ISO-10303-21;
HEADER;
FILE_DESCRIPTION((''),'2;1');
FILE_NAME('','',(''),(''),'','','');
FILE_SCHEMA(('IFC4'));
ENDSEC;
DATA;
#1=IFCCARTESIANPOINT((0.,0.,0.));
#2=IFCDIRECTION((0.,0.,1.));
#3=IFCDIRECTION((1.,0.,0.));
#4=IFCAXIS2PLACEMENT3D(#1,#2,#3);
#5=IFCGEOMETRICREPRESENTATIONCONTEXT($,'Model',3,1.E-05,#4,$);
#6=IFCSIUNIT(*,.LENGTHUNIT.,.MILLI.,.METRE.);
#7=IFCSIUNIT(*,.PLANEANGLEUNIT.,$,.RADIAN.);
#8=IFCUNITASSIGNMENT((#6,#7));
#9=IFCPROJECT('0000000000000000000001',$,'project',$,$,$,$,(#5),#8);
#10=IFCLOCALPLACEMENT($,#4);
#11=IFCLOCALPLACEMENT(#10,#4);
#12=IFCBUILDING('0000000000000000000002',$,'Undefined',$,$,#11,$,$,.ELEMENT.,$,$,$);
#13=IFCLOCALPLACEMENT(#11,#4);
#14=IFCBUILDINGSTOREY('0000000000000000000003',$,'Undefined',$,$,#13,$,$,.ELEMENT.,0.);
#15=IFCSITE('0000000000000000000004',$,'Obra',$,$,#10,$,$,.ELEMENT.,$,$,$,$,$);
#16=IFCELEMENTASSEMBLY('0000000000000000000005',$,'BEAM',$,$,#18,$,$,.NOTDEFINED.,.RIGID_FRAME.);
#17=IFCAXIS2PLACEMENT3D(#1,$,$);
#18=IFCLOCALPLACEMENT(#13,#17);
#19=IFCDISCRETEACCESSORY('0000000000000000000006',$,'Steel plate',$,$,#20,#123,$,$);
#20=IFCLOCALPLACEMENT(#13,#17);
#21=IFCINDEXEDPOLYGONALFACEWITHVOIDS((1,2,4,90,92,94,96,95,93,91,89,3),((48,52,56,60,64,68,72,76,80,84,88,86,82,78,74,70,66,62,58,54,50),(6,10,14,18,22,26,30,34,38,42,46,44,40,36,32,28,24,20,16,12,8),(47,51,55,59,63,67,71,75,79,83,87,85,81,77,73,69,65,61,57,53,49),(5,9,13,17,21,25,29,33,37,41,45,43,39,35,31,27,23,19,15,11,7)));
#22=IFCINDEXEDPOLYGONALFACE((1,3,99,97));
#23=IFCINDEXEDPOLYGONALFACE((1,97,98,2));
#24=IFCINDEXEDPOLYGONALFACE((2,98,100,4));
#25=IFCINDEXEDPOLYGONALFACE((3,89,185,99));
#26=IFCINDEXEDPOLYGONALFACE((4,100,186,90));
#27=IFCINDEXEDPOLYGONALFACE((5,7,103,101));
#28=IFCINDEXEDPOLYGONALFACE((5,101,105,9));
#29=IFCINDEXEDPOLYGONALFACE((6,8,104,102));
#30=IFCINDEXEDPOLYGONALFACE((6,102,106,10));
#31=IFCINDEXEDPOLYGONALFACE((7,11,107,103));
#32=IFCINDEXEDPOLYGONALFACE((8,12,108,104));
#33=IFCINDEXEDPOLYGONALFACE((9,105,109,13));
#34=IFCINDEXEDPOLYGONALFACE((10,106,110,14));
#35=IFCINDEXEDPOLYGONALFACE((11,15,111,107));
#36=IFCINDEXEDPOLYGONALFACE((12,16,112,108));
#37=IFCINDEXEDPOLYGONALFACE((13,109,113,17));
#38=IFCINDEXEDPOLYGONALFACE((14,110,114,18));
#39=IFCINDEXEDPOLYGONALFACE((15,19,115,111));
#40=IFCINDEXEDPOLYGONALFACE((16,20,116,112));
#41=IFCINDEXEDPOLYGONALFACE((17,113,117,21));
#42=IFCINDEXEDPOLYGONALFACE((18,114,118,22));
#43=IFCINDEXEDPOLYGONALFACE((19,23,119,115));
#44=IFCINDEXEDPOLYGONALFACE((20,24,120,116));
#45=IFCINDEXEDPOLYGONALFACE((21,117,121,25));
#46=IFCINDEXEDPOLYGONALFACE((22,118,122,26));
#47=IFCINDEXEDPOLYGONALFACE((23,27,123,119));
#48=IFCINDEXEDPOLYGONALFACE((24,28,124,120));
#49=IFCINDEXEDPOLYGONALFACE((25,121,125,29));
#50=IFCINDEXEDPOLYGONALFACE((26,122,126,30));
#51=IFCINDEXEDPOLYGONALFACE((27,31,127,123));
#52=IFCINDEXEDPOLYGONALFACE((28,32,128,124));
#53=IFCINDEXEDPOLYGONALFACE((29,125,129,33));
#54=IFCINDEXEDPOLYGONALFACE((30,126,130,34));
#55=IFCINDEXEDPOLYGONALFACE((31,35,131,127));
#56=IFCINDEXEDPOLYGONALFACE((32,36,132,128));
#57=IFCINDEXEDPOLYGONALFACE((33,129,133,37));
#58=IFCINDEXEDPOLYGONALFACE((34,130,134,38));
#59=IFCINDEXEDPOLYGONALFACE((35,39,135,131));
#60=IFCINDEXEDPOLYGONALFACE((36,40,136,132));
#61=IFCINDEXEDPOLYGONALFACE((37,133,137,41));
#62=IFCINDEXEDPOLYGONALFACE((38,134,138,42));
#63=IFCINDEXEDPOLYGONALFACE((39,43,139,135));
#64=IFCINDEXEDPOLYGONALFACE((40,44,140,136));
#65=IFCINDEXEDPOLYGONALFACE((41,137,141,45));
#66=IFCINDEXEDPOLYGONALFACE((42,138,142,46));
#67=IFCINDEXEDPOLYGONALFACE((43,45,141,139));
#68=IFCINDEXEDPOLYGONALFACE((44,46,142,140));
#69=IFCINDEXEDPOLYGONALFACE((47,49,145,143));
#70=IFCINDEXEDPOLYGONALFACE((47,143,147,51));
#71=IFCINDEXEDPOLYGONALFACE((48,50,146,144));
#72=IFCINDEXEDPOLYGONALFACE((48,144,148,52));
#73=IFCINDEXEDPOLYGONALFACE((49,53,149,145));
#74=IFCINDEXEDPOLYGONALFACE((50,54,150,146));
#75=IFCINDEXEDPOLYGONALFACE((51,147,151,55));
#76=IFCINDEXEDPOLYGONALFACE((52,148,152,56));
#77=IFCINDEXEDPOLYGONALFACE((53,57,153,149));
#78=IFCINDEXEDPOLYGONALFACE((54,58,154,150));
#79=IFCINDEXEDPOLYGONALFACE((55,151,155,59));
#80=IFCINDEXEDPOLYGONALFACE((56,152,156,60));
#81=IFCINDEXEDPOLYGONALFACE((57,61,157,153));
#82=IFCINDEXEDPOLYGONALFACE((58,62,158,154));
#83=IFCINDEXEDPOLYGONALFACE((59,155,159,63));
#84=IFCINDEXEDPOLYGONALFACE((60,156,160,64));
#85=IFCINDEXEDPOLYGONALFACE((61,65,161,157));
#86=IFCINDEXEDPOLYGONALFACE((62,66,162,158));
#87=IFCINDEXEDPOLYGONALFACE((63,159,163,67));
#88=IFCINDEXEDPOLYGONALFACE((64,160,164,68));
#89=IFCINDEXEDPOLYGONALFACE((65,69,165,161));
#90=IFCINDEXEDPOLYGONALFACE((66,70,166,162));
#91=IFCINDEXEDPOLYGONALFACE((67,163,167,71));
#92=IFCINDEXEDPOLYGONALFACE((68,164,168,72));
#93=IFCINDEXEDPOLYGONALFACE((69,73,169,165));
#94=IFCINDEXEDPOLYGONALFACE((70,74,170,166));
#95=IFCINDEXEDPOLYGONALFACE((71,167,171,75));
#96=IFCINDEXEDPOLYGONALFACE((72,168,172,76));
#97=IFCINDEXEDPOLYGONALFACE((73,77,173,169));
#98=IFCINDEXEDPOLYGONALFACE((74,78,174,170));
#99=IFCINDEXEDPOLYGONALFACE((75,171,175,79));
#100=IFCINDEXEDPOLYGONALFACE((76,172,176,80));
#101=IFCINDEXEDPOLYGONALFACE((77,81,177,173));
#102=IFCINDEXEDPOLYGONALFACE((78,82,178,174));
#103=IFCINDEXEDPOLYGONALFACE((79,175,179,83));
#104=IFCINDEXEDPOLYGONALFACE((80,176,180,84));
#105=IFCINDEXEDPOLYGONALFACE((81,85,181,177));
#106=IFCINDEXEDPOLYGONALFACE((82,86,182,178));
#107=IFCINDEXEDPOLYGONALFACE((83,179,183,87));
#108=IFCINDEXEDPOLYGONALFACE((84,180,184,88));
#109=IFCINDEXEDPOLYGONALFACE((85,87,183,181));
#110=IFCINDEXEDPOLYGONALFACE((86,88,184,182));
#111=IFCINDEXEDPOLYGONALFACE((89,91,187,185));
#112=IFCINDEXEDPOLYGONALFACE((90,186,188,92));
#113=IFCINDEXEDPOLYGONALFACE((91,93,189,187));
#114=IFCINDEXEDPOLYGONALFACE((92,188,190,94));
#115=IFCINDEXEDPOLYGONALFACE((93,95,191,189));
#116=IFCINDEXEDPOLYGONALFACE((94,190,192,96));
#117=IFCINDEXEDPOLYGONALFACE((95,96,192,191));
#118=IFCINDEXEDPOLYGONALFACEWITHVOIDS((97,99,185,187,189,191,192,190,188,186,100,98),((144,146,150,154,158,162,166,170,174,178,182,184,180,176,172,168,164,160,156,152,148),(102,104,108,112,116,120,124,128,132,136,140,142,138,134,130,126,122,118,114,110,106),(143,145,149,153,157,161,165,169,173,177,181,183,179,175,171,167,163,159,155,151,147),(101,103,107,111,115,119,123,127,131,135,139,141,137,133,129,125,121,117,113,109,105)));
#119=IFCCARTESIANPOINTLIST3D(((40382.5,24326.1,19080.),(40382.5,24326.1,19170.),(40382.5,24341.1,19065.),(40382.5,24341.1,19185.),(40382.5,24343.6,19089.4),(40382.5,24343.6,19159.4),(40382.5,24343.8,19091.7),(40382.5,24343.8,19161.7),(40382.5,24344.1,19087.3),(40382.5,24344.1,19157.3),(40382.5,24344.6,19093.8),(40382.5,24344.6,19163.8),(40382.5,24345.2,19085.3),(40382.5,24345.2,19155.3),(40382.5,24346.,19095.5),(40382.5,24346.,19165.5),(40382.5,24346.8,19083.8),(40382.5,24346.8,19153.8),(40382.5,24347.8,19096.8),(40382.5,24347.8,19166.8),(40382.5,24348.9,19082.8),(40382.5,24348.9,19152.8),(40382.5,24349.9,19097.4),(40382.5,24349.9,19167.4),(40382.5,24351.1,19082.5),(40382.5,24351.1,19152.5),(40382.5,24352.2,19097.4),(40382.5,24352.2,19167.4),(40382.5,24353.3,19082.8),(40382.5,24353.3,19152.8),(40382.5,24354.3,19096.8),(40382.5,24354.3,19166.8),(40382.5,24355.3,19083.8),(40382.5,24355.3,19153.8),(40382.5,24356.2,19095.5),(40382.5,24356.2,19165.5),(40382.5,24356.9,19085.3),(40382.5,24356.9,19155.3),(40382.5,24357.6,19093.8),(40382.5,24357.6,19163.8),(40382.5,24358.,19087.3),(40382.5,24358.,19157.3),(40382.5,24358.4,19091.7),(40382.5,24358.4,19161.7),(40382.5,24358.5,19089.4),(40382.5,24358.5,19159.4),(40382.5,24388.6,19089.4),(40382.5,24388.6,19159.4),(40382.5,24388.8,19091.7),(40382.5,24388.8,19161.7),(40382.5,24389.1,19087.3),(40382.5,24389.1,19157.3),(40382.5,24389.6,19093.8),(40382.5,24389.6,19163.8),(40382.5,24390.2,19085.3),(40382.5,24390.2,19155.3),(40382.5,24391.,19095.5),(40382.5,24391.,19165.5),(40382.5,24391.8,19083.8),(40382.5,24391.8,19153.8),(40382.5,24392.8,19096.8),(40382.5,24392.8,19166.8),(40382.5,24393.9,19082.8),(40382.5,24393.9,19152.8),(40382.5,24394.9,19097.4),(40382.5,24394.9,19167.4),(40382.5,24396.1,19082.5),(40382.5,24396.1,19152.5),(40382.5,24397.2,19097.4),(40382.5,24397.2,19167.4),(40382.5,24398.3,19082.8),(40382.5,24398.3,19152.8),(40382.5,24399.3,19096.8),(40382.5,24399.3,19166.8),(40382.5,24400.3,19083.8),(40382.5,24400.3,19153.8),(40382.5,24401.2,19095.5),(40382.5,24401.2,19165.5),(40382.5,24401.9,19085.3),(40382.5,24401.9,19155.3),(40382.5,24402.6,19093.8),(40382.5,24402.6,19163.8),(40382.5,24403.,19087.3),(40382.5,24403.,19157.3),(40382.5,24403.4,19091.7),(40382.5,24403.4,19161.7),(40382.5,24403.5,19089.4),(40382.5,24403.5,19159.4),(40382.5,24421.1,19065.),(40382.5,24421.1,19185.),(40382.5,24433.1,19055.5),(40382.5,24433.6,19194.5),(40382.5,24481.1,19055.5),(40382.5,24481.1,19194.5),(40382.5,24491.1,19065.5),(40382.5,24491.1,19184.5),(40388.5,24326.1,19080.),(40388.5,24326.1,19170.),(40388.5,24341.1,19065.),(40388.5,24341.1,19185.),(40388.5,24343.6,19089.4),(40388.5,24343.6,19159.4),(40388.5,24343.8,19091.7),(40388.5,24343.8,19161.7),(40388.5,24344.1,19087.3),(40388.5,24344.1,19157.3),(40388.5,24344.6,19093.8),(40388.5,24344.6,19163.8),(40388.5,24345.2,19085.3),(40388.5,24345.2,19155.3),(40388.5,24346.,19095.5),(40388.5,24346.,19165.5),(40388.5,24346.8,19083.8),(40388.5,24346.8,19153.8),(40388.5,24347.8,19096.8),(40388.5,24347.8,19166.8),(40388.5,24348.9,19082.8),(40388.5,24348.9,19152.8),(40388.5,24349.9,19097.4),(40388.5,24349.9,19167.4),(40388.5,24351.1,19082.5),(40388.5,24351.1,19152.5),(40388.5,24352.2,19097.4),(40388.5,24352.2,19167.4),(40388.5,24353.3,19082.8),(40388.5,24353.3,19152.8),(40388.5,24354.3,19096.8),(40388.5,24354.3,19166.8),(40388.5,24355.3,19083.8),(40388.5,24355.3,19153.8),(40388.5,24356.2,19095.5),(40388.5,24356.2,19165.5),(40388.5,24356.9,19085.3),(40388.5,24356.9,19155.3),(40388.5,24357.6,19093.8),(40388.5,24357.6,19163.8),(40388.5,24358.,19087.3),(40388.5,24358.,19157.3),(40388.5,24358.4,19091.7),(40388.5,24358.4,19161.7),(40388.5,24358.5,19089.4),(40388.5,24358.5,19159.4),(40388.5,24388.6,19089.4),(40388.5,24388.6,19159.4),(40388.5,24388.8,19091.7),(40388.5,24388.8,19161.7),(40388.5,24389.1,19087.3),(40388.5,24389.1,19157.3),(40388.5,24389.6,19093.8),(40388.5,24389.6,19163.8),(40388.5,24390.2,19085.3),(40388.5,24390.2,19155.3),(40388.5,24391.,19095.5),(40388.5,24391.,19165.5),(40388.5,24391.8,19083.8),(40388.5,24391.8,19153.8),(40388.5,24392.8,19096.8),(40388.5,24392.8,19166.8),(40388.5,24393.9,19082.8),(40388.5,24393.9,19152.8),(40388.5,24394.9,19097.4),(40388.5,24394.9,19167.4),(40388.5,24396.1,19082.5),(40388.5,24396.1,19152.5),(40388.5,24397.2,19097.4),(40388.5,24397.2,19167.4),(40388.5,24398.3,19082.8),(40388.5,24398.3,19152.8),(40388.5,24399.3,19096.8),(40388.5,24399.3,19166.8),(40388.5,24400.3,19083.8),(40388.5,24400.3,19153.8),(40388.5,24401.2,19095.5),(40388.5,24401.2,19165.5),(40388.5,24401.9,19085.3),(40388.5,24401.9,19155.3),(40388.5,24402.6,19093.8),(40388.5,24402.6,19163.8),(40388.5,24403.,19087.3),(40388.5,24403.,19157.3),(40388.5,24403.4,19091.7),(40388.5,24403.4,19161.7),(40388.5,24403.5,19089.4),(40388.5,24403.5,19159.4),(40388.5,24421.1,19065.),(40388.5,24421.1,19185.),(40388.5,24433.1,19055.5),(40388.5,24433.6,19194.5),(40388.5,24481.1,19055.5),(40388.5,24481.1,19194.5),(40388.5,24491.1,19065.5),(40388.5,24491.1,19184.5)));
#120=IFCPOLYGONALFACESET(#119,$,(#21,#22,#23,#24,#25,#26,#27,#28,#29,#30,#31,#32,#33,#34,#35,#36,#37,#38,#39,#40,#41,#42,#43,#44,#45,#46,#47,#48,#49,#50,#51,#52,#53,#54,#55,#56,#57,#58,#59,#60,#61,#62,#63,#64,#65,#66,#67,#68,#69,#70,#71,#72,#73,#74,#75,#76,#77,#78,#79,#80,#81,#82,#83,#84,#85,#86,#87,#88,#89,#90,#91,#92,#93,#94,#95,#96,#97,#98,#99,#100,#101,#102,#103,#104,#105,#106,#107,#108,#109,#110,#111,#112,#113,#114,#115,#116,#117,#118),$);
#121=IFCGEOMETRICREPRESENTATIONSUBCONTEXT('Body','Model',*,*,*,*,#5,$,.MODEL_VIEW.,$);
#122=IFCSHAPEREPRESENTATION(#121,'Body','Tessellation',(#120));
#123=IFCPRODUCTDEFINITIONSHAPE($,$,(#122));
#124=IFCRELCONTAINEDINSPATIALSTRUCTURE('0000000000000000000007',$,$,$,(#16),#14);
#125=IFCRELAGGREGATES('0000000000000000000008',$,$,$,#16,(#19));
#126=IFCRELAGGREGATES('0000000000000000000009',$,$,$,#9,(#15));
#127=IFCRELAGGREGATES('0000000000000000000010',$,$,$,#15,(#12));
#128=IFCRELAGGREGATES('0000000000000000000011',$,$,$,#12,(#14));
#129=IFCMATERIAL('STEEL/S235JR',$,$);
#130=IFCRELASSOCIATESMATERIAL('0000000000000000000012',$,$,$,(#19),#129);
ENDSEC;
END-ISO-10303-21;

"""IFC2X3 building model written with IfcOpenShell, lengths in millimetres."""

from ifc_helpers import new_model, si_unit, frame, origin_with_axes, origin_2d_with_axis, place, context, subcontext, project, spatial, polyline, circle, outline, extrude, source, transform, mapped, material, element, aggregate, save


model = new_model("IFC2X3")

# Units and contexts
model_context = context("Model", 3, precision=1e-05, world=origin_with_axes())
body_context = subcontext(model_context, "Body", "Model", "MODEL_VIEW")
ifc_project = project(units=[si_unit("LENGTHUNIT", "METRE", prefix="MILLI"), si_unit("PLANEANGLEUNIT", "RADIAN")], contexts=[model_context])

# Site, building, storey
site_placement = place(None, origin_with_axes())
site = spatial("IfcSite", under=ifc_project, at=site_placement, Name="Obra", CompositionType="ELEMENT")
building_placement = place(site_placement, origin_with_axes())
building = spatial("IfcBuilding", under=site, at=building_placement, Name="Undefined", CompositionType="ELEMENT")
storey_placement = place(building_placement, origin_with_axes())
storey = spatial("IfcBuildingStorey", under=building, at=storey_placement, Name="Undefined", CompositionType="ELEMENT", Elevation=0.0)

# Shared definitions
ifc_material_1 = material(Name="STEEL/S235JR")

# Element assembly
assembly_1_placement = place(storey_placement, origin_with_axes())
assembly_1 = element("IfcElementAssembly", 1, at=assembly_1_placement, inside=storey, Name="BEAM", AssemblyPlace="NOTDEFINED", PredefinedType="RIGID_FRAME")

# Discrete accessory, opening
discrete_accessory_1_placement = place(assembly_1_placement, frame((40385.5, 24491.1, 19065.5), z_axis=(-1.0, 0.0, 0.0), x_axis=(0.0, -0.707107, -0.707107)))
discrete_accessory_1 = element("IfcDiscreteAccessory", 2, at=discrete_accessory_1_placement, material=ifc_material_1, Name="Steel plate", context=body_context, shape_type="SweptSolid", body=[
    extrude(outline(polyline([(0.0, 0.0), (14.1, 0.0), (48.1, 33.9), (49.9, 49.1), (106.4, 105.7), (106.4, 126.9), (42.8, 190.6), (21.6, 190.6), (-35.0, 134.0), (-50.6, 131.9), (-84.1, 98.3), (-84.1, 84.1), (0.0, 0.0)])), frame((0.0, 0.0, -3.0), z_axis=(0.0, 0.0, 1.0), x_axis=(1.0, 0.0, 0.0)), (0.0, 0.0, 1.0), 6.0),
])
shared_shape_1 = source(origin_with_axes(), body_context, "Body", "SweptSolid", [
    extrude(circle(Radius=7.5, at=origin_2d_with_axis()), frame((0.0, 2.4, 0.0), z_axis=(0.0, 1.0, 0.0), x_axis=(1.0, 0.0, 0.0)), (0.0, 0.0, 1.0), 6.2),
])
opening_1_placement = place(assembly_1_placement, frame((40380.0, 24373.6, 19160.0), z_axis=(0.0, -1.0, 0.0), x_axis=(0.0, 0.0, -1.0)))
element("IfcOpeningElement", 3, at=opening_1_placement, cuts=discrete_accessory_1, ObjectType="Opening", context=body_context, shape_type="MappedRepresentation", body=[
    mapped(shared_shape_1, transform((0.0, 0.0, -22.5))),
    mapped(shared_shape_1, transform((70.0, 0.0, -22.5))),
    mapped(shared_shape_1, transform((0.0, 0.0, 22.5))),
    mapped(shared_shape_1, transform((70.0, 0.0, 22.5))),
])

aggregate(assembly_1, [discrete_accessory_1])

save(model, "model.ifc")
